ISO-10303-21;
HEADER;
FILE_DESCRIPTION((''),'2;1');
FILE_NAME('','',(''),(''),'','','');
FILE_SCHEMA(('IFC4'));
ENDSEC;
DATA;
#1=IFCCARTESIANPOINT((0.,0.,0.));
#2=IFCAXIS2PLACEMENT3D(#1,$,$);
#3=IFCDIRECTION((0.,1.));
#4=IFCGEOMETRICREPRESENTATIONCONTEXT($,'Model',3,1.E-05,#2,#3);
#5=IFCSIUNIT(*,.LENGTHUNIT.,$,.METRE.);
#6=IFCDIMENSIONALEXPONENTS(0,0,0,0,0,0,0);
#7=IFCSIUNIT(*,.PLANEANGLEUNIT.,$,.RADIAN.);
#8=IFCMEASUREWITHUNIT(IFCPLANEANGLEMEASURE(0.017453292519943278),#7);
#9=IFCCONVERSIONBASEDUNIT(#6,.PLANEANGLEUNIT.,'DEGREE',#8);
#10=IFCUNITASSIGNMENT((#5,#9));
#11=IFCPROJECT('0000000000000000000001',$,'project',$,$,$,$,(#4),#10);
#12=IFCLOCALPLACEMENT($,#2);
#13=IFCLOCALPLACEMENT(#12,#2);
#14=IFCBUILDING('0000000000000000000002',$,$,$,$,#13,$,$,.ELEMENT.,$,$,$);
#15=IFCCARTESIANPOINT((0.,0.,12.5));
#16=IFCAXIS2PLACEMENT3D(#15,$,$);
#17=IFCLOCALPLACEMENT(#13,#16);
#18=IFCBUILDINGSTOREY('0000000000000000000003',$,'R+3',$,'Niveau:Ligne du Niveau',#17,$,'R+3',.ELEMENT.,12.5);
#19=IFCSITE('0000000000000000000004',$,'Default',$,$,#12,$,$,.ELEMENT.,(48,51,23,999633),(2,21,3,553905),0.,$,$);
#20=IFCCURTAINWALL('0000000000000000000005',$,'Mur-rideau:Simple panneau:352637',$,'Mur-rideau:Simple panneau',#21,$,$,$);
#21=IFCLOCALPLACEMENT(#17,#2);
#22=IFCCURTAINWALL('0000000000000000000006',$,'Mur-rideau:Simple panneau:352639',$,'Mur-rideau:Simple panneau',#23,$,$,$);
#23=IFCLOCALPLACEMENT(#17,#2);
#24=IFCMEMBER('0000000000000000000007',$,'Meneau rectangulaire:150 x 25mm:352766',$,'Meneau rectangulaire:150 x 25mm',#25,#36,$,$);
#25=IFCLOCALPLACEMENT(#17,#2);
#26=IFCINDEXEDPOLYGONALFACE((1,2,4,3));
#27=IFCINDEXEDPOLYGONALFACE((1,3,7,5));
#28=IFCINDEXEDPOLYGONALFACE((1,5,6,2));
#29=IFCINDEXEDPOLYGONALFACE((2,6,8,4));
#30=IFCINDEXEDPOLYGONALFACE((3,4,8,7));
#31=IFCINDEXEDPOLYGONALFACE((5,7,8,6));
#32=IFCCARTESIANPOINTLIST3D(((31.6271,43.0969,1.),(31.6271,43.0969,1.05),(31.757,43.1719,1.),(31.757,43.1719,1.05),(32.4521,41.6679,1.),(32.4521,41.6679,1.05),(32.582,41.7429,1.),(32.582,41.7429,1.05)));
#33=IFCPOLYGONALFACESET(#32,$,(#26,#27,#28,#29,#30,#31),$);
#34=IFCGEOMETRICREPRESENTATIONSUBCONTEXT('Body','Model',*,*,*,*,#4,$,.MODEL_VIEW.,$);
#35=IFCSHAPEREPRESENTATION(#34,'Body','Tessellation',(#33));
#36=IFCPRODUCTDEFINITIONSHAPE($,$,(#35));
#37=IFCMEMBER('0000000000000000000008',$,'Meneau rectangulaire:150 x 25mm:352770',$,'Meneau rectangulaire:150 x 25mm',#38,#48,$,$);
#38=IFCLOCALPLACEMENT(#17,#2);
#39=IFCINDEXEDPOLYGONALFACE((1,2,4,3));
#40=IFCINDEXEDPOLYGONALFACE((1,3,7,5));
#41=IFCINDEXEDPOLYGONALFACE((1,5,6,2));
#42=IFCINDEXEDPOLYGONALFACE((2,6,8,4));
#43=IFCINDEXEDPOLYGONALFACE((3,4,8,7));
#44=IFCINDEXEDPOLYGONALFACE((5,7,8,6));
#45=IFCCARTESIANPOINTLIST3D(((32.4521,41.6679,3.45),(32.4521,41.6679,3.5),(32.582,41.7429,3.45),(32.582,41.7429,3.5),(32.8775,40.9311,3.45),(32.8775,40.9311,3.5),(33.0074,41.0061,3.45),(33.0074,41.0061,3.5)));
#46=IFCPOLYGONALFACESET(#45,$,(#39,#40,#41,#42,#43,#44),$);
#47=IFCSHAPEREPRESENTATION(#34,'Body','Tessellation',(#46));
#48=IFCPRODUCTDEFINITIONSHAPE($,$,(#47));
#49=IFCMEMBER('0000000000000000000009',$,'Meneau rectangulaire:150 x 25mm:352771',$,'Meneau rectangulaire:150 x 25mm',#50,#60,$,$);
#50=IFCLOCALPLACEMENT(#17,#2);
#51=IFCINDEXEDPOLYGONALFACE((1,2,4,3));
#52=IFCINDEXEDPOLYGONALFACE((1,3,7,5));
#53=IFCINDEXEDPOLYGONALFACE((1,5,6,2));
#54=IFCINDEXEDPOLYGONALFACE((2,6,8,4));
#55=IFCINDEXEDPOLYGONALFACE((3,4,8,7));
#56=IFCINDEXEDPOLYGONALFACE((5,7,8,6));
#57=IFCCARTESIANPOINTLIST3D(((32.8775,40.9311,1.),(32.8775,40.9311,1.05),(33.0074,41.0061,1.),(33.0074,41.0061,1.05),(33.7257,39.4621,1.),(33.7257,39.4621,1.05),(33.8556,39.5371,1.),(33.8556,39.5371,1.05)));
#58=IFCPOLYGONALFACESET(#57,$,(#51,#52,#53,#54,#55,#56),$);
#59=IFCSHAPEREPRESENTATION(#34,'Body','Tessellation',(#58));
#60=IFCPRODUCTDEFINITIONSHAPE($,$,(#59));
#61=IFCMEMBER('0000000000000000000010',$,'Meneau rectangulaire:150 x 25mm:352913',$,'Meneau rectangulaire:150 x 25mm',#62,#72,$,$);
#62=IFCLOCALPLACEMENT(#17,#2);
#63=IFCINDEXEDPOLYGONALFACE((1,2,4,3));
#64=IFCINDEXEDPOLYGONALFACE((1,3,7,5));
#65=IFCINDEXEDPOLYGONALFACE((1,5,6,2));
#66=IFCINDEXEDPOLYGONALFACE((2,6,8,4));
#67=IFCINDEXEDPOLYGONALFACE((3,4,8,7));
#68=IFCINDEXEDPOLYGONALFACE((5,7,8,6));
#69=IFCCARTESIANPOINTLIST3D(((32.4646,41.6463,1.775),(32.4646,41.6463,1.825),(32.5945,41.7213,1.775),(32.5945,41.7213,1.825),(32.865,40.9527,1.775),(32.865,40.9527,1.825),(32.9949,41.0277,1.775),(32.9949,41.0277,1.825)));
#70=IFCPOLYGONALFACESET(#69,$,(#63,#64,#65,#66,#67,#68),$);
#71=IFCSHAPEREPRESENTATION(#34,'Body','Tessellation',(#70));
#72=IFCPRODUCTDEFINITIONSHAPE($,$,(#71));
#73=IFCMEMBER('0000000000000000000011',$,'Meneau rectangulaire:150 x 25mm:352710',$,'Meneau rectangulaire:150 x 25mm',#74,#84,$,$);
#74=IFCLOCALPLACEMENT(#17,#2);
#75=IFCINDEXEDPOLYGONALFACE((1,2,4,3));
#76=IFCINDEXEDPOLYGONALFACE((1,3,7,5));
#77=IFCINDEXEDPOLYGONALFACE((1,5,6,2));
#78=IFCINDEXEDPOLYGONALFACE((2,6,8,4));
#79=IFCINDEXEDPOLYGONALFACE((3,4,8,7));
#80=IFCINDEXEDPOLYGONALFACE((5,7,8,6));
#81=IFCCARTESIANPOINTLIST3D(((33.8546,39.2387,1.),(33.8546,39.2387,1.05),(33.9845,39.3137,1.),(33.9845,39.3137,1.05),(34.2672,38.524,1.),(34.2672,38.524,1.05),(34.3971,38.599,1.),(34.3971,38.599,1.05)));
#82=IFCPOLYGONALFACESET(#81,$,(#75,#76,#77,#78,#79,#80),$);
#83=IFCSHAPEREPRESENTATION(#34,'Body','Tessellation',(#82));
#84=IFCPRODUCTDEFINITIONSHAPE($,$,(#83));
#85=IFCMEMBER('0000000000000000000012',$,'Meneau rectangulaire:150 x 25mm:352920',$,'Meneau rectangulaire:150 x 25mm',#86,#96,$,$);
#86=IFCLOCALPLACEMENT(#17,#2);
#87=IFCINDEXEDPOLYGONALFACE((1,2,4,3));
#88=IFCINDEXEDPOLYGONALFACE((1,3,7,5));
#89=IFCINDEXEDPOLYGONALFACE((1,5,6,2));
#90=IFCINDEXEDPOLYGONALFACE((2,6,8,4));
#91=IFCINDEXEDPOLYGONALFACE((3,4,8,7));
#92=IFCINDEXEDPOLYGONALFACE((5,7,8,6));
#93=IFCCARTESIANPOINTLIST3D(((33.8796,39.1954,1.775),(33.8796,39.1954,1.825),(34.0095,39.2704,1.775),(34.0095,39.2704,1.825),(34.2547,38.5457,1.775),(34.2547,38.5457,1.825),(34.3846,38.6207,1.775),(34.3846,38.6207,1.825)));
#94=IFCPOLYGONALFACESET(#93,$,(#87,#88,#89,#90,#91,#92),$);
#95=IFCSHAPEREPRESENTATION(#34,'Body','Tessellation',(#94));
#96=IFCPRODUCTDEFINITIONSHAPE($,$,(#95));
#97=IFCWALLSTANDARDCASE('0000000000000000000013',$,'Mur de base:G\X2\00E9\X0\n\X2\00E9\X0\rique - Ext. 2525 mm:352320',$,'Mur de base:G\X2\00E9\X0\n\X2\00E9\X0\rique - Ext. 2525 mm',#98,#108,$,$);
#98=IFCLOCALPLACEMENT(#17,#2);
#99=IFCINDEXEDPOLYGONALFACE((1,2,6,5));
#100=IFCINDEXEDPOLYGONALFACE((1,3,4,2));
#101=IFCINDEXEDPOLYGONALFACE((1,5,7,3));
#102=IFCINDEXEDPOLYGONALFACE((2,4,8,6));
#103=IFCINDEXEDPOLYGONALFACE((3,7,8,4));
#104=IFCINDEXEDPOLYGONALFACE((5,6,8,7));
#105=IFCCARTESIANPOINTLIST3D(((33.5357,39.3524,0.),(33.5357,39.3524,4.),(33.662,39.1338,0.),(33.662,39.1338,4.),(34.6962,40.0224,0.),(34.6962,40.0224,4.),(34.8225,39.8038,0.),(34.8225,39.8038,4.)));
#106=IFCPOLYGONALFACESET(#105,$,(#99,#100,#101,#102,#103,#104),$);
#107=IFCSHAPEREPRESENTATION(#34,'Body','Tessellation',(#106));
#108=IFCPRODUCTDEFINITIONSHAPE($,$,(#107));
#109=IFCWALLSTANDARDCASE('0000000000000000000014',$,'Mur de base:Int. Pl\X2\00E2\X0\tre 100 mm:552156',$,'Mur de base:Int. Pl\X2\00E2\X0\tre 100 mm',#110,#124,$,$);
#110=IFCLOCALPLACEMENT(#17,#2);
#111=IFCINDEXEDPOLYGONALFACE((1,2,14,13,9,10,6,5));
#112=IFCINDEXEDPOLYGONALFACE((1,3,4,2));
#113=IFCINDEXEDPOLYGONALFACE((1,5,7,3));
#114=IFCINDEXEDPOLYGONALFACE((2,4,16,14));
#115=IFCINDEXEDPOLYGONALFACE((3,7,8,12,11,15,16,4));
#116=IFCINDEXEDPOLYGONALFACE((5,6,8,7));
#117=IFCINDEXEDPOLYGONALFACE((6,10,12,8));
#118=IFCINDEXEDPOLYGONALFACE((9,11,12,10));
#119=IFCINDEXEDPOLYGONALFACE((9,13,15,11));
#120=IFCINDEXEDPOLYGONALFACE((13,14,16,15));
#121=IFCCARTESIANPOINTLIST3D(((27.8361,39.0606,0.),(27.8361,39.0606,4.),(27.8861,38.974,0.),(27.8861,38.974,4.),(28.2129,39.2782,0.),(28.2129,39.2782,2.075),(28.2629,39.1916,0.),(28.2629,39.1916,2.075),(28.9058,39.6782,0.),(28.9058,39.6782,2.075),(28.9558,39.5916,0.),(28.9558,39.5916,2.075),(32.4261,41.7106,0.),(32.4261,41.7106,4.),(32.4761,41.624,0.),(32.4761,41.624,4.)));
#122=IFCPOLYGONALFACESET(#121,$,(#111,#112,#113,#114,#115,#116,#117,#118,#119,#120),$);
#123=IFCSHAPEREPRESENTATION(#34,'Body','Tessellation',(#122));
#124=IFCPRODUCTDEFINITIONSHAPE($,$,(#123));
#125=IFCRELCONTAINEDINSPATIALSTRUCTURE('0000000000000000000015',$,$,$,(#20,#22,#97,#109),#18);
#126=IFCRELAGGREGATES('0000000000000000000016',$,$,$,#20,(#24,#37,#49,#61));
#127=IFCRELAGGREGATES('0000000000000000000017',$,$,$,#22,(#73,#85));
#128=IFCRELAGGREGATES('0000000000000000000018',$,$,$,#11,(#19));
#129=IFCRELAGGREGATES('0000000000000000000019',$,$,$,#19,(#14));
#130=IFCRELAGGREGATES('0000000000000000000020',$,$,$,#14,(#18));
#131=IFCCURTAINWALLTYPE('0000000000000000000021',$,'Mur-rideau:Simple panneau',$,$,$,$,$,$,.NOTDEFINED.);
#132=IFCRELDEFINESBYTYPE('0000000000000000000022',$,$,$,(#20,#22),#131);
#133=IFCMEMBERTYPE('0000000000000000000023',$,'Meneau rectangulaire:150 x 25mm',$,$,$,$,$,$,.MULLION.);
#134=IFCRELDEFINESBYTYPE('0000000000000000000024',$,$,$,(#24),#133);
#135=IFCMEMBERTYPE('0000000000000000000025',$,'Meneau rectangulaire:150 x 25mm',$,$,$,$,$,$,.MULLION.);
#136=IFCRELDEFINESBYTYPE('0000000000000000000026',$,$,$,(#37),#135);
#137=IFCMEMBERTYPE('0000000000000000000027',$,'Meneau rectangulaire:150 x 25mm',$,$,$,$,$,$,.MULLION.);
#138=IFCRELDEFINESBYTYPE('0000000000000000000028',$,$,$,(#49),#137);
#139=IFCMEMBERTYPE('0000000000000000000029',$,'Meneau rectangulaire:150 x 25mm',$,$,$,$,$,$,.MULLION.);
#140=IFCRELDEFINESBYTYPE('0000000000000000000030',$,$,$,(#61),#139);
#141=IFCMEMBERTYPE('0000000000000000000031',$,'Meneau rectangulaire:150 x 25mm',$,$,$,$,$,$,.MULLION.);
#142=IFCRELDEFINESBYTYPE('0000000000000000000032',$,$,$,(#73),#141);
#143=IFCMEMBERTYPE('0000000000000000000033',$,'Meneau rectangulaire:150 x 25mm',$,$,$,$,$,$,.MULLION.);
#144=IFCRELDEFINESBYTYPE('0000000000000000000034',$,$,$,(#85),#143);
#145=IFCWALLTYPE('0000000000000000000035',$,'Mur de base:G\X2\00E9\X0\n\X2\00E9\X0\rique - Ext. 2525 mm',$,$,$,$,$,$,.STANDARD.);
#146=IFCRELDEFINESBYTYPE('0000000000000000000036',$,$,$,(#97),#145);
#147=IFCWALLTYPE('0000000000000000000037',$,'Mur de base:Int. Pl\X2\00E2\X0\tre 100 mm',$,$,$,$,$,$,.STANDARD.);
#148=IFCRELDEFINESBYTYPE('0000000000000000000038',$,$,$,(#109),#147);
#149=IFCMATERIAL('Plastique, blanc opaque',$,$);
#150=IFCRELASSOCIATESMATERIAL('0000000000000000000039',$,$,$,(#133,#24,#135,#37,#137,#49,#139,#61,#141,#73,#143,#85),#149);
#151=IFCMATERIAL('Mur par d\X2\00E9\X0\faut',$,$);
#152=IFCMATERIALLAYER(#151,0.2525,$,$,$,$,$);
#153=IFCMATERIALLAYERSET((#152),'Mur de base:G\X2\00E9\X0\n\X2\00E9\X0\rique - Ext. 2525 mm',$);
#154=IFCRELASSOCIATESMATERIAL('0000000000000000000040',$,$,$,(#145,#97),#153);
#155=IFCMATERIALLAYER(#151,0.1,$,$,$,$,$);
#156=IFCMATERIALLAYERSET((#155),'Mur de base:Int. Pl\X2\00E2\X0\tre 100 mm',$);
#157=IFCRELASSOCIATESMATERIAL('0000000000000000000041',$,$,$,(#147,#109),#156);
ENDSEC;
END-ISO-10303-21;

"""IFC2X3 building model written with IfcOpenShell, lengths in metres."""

from ifc_helpers import new_model, entity, si_unit, converted_unit, direction, frame, frame_2d, origin, origin_2d_with_axis, place, context, subcontext, project, spatial, polyline, rectangle, outline, extrude, source, transform, mapped, material, layer, layer_set, layer_usage, type_object, type_shapes, element, aggregate, save


model = new_model("IFC2X3")

# Units and contexts
model_context = context("Model", 3, precision=1e-05, world=origin(), true_north=direction((0.0, 1.0)))
body_context = subcontext(model_context, "Body", "Model", "MODEL_VIEW")
ifc_project = project(units=[si_unit("LENGTHUNIT", "METRE"), converted_unit("PLANEANGLEUNIT", "DEGREE", entity("IfcPlaneAngleMeasure", 0.017453292519943278), si_unit("PLANEANGLEUNIT", "RADIAN"), dimensions=[0, 0, 0, 0, 0, 0, 0])], contexts=[model_context])

# Site, building, storey
site_placement = place(None, origin())
site = spatial("IfcSite", under=ifc_project, at=site_placement, Name="Default", CompositionType="ELEMENT", RefLatitude=(48, 51, 23, 999633), RefLongitude=(2, 21, 3, 553905), RefElevation=0.0)
building_placement = place(site_placement, origin())
building = spatial("IfcBuilding", under=site, at=building_placement, CompositionType="ELEMENT")
storey_placement = place(building_placement, frame((0.0, 0.0, 12.5)))
storey = spatial("IfcBuildingStorey", under=building, at=storey_placement, Name="R+3", ObjectType="Niveau:Ligne du Niveau", LongName="R+3", CompositionType="ELEMENT", Elevation=12.5)

# Curtain walls
curtain_wall_type = type_object("IfcCurtainWallType", Name="Mur-rideau:Simple panneau", PredefinedType="NOTDEFINED")
curtain_wall_1_placement = place(storey_placement, frame((0.0, 0.0, -12.5)))
curtain_wall_1 = element("IfcCurtainWall", 1, at=curtain_wall_1_placement, inside=storey, type_object=curtain_wall_type, Name="Mur-rideau:Simple panneau:352637", ObjectType="Mur-rideau:Simple panneau")
ifc_material_1 = material(Name="Plastique, blanc opaque")
curtain_wall_2_placement = place(storey_placement, frame((0.0, 0.0, -12.5)))
curtain_wall_2 = element("IfcCurtainWall", 2, at=curtain_wall_2_placement, inside=storey, type_object=curtain_wall_type, Name="Mur-rideau:Simple panneau:352639", ObjectType="Mur-rideau:Simple panneau")

# Members
member_type_1 = type_object("IfcMemberType", Name="Meneau rectangulaire:150 x 25mm", PredefinedType="MULLION", material=ifc_material_1)
shared_shape_1 = source(origin(), body_context, "Body", "SweptSolid", [
    extrude(rectangle(XDim=0.05, YDim=0.15, at=origin_2d_with_axis()), frame((-0.025, 0.0, -1.65), z_axis=(0.0, 0.0, 1.0), x_axis=(-1.0, 0.0, 0.0)), (0.0, 0.0, 1.0), 1.65),
])
type_shapes(member_type_1, [shared_shape_1])
member_1_placement = place(curtain_wall_1_placement, frame((31.6921, 43.1344, 13.5), z_axis=(-0.5, 0.866025, 0.0), x_axis=(0.0, 0.0, -1.0)))
member_1 = element("IfcMember", 3, at=member_1_placement, type_object=member_type_1, material=ifc_material_1, Name="Meneau rectangulaire:150 x 25mm:352766", ObjectType="Meneau rectangulaire:150 x 25mm", context=body_context, shape_type="MappedRepresentation", body=[
    mapped(shared_shape_1, transform((0.0, 0.0, 0.0), scale=1.0)),
])
member_type_2 = type_object("IfcMemberType", Name="Meneau rectangulaire:150 x 25mm", PredefinedType="MULLION", material=ifc_material_1)
shared_shape_2 = source(origin(), body_context, "Body", "SweptSolid", [
    extrude(rectangle(XDim=0.05, YDim=0.15, at=origin_2d_with_axis()), frame((-0.025, 0.0, -0.8508), z_axis=(0.0, 0.0, 1.0), x_axis=(-1.0, 0.0, 0.0)), (0.0, 0.0, 1.0), 0.8508),
])
type_shapes(member_type_2, [shared_shape_2])
member_2_placement = place(curtain_wall_1_placement, frame((32.9425, 40.9686, 16.0), z_axis=(0.5, -0.866025, 0.0), x_axis=(0.0, 0.0, 1.0)))
member_2 = element("IfcMember", 4, at=member_2_placement, type_object=member_type_2, material=ifc_material_1, Name="Meneau rectangulaire:150 x 25mm:352770", ObjectType="Meneau rectangulaire:150 x 25mm", context=body_context, shape_type="MappedRepresentation", body=[
    mapped(shared_shape_2, transform((0.0, 0.0, 0.0), scale=1.0)),
])
member_type_3 = type_object("IfcMemberType", Name="Meneau rectangulaire:150 x 25mm", PredefinedType="MULLION", material=ifc_material_1)
shared_shape_3 = source(origin(), body_context, "Body", "SweptSolid", [
    extrude(rectangle(XDim=0.05, YDim=0.15, at=origin_2d_with_axis()), frame((-0.025, 0.0, -1.6963), z_axis=(0.0, 0.0, 1.0), x_axis=(-1.0, 0.0, 0.0)), (0.0, 0.0, 1.0), 1.6963),
])
type_shapes(member_type_3, [shared_shape_3])
member_3_placement = place(curtain_wall_1_placement, frame((32.9425, 40.9686, 13.5), z_axis=(-0.5, 0.866025, 0.0), x_axis=(0.0, 0.0, -1.0)))
member_3 = element("IfcMember", 5, at=member_3_placement, type_object=member_type_3, material=ifc_material_1, Name="Meneau rectangulaire:150 x 25mm:352771", ObjectType="Meneau rectangulaire:150 x 25mm", context=body_context, shape_type="MappedRepresentation", body=[
    mapped(shared_shape_3, transform((0.0, 0.0, 0.0), scale=1.0)),
])
member_type_4 = type_object("IfcMemberType", Name="Meneau rectangulaire:150 x 25mm", PredefinedType="MULLION", material=ifc_material_1)
shared_shape_4 = source(origin(), body_context, "Body", "SweptSolid", [
    extrude(rectangle(XDim=0.05, YDim=0.15, at=origin_2d_with_axis()), frame((0.0, 0.0, -0.8008), z_axis=(0.0, 0.0, 1.0), x_axis=(-1.0, 0.0, 0.0)), (0.0, 0.0, 1.0), 0.8008),
])
type_shapes(member_type_4, [shared_shape_4])
member_4_placement = place(curtain_wall_1_placement, frame((32.93, 40.9902, 14.3), z_axis=(0.5, -0.866025, 0.0), x_axis=(0.0, 0.0, 1.0)))
member_4 = element("IfcMember", 6, at=member_4_placement, type_object=member_type_4, material=ifc_material_1, Name="Meneau rectangulaire:150 x 25mm:352913", ObjectType="Meneau rectangulaire:150 x 25mm", context=body_context, shape_type="MappedRepresentation", body=[
    mapped(shared_shape_4, transform((0.0, 0.0, 0.0), scale=1.0)),
])
member_type_5 = type_object("IfcMemberType", Name="Meneau rectangulaire:150 x 25mm", PredefinedType="MULLION", material=ifc_material_1)
shared_shape_5 = source(origin(), body_context, "Body", "SweptSolid", [
    extrude(rectangle(XDim=0.05, YDim=0.15, at=origin_2d_with_axis()), frame((-0.025, 0.0, -0.8253), z_axis=(0.0, 0.0, 1.0), x_axis=(-1.0, 0.0, 0.0)), (0.0, 0.0, 1.0), 0.8253),
])
type_shapes(member_type_5, [shared_shape_5])
member_5_placement = place(curtain_wall_2_placement, frame((33.9196, 39.2762, 13.5), z_axis=(-0.5, 0.866025, 0.0), x_axis=(0.0, 0.0, -1.0)))
member_5 = element("IfcMember", 7, at=member_5_placement, type_object=member_type_5, material=ifc_material_1, Name="Meneau rectangulaire:150 x 25mm:352710", ObjectType="Meneau rectangulaire:150 x 25mm", context=body_context, shape_type="MappedRepresentation", body=[
    mapped(shared_shape_5, transform((0.0, 0.0, 0.0), scale=1.0)),
])
member_type_6 = type_object("IfcMemberType", Name="Meneau rectangulaire:150 x 25mm", PredefinedType="MULLION", material=ifc_material_1)
shared_shape_6 = source(origin(), body_context, "Body", "SweptSolid", [
    extrude(rectangle(XDim=0.05, YDim=0.15, at=origin_2d_with_axis()), frame((0.0, 0.0, -0.7503), z_axis=(0.0, 0.0, 1.0), x_axis=(-1.0, 0.0, 0.0)), (0.0, 0.0, 1.0), 0.7503),
])
type_shapes(member_type_6, [shared_shape_6])
member_6_placement = place(curtain_wall_2_placement, frame((34.3197, 38.5832, 14.3), z_axis=(0.5, -0.866025, 0.0), x_axis=(0.0, 0.0, 1.0)))
member_6 = element("IfcMember", 8, at=member_6_placement, type_object=member_type_6, material=ifc_material_1, Name="Meneau rectangulaire:150 x 25mm:352920", ObjectType="Meneau rectangulaire:150 x 25mm", context=body_context, shape_type="MappedRepresentation", body=[
    mapped(shared_shape_6, transform((0.0, 0.0, 0.0), scale=1.0)),
])

aggregate(curtain_wall_1, [member_1, member_2, member_3, member_4])
aggregate(curtain_wall_2, [member_5, member_6])

# Wall
ifc_material_2 = material(Name="Mur par défaut")
ifc_layer_1 = layer(ifc_material_2, 0.2525)
ifc_layer_set_1 = layer_set([ifc_layer_1], Name="Mur de base:Générique - Ext. 2525 mm")
ifc_layer_usage_1 = layer_usage(ifc_layer_set_1, "AXIS2", "POSITIVE", -0.1263)
wall_type_1 = type_object("IfcWallType", Name="Mur de base:Générique - Ext. 2525 mm", PredefinedType="STANDARD", material=ifc_layer_set_1)
wall_1_placement = place(storey_placement, frame((33.5989, 39.2431, 0.0), z_axis=(0.0, 0.0, 1.0), x_axis=(0.866025, 0.5, 0.0)))
element("IfcWallStandardCase", 9, at=wall_1_placement, inside=storey, type_object=wall_type_1, material=ifc_layer_usage_1, Name="Mur de base:Générique - Ext. 2525 mm:352320", ObjectType="Mur de base:Générique - Ext. 2525 mm", context=body_context, shape_type="SweptSolid", body=[
    extrude(rectangle(XDim=1.34, YDim=0.2525, at=frame_2d((0.67, 0.0), x_axis=(-1.0, 0.0))), origin(), (0.0, 0.0, 1.0), 4.0),
])

# Wall, opening
ifc_layer_2 = layer(ifc_material_2, 0.1)
ifc_layer_set_2 = layer_set([ifc_layer_2], Name="Mur de base:Int. Plâtre 100 mm")
ifc_layer_usage_2 = layer_usage(ifc_layer_set_2, "AXIS2", "NEGATIVE", 0.05)
wall_type_2 = type_object("IfcWallType", Name="Mur de base:Int. Plâtre 100 mm", PredefinedType="STANDARD", material=ifc_layer_set_2)
wall_2_placement = place(storey_placement, frame((32.4511, 41.6673, 0.0), z_axis=(0.0, 0.0, 1.0), x_axis=(-0.866025, -0.5, 0.0)))
wall_2 = element("IfcWallStandardCase", 10, at=wall_2_placement, inside=storey, type_object=wall_type_2, material=ifc_layer_usage_2, Name="Mur de base:Int. Plâtre 100 mm:552156", ObjectType="Mur de base:Int. Plâtre 100 mm", context=body_context, shape_type="SweptSolid", body=[
    extrude(outline(polyline([(0.0, -0.05), (3.5988, -0.05), (3.6988, -0.05), (5.3, -0.05), (5.3, 0.05), (0.0, 0.05), (0.0, -0.05)])), origin(), (0.0, 0.0, 1.0), 4.0),
])
opening_placement = place(wall_2_placement, frame((4.0649, -0.05, 0.0)))
element("IfcOpeningElement", 11, at=opening_placement, cuts=wall_2, ObjectType="Opening", context=body_context, shape_type="SweptSolid", body=[
    extrude(rectangle(XDim=2.075, YDim=0.8, at=frame_2d((1.0375, 0.4), x_axis=(1.0, 0.0))), frame((0.0, 0.0, 0.0), z_axis=(0.0, 1.0, 0.0), x_axis=(0.0, 0.0, 1.0)), (0.0, 0.0, 1.0), 0.1),
])

save(model, "model.ifc")
